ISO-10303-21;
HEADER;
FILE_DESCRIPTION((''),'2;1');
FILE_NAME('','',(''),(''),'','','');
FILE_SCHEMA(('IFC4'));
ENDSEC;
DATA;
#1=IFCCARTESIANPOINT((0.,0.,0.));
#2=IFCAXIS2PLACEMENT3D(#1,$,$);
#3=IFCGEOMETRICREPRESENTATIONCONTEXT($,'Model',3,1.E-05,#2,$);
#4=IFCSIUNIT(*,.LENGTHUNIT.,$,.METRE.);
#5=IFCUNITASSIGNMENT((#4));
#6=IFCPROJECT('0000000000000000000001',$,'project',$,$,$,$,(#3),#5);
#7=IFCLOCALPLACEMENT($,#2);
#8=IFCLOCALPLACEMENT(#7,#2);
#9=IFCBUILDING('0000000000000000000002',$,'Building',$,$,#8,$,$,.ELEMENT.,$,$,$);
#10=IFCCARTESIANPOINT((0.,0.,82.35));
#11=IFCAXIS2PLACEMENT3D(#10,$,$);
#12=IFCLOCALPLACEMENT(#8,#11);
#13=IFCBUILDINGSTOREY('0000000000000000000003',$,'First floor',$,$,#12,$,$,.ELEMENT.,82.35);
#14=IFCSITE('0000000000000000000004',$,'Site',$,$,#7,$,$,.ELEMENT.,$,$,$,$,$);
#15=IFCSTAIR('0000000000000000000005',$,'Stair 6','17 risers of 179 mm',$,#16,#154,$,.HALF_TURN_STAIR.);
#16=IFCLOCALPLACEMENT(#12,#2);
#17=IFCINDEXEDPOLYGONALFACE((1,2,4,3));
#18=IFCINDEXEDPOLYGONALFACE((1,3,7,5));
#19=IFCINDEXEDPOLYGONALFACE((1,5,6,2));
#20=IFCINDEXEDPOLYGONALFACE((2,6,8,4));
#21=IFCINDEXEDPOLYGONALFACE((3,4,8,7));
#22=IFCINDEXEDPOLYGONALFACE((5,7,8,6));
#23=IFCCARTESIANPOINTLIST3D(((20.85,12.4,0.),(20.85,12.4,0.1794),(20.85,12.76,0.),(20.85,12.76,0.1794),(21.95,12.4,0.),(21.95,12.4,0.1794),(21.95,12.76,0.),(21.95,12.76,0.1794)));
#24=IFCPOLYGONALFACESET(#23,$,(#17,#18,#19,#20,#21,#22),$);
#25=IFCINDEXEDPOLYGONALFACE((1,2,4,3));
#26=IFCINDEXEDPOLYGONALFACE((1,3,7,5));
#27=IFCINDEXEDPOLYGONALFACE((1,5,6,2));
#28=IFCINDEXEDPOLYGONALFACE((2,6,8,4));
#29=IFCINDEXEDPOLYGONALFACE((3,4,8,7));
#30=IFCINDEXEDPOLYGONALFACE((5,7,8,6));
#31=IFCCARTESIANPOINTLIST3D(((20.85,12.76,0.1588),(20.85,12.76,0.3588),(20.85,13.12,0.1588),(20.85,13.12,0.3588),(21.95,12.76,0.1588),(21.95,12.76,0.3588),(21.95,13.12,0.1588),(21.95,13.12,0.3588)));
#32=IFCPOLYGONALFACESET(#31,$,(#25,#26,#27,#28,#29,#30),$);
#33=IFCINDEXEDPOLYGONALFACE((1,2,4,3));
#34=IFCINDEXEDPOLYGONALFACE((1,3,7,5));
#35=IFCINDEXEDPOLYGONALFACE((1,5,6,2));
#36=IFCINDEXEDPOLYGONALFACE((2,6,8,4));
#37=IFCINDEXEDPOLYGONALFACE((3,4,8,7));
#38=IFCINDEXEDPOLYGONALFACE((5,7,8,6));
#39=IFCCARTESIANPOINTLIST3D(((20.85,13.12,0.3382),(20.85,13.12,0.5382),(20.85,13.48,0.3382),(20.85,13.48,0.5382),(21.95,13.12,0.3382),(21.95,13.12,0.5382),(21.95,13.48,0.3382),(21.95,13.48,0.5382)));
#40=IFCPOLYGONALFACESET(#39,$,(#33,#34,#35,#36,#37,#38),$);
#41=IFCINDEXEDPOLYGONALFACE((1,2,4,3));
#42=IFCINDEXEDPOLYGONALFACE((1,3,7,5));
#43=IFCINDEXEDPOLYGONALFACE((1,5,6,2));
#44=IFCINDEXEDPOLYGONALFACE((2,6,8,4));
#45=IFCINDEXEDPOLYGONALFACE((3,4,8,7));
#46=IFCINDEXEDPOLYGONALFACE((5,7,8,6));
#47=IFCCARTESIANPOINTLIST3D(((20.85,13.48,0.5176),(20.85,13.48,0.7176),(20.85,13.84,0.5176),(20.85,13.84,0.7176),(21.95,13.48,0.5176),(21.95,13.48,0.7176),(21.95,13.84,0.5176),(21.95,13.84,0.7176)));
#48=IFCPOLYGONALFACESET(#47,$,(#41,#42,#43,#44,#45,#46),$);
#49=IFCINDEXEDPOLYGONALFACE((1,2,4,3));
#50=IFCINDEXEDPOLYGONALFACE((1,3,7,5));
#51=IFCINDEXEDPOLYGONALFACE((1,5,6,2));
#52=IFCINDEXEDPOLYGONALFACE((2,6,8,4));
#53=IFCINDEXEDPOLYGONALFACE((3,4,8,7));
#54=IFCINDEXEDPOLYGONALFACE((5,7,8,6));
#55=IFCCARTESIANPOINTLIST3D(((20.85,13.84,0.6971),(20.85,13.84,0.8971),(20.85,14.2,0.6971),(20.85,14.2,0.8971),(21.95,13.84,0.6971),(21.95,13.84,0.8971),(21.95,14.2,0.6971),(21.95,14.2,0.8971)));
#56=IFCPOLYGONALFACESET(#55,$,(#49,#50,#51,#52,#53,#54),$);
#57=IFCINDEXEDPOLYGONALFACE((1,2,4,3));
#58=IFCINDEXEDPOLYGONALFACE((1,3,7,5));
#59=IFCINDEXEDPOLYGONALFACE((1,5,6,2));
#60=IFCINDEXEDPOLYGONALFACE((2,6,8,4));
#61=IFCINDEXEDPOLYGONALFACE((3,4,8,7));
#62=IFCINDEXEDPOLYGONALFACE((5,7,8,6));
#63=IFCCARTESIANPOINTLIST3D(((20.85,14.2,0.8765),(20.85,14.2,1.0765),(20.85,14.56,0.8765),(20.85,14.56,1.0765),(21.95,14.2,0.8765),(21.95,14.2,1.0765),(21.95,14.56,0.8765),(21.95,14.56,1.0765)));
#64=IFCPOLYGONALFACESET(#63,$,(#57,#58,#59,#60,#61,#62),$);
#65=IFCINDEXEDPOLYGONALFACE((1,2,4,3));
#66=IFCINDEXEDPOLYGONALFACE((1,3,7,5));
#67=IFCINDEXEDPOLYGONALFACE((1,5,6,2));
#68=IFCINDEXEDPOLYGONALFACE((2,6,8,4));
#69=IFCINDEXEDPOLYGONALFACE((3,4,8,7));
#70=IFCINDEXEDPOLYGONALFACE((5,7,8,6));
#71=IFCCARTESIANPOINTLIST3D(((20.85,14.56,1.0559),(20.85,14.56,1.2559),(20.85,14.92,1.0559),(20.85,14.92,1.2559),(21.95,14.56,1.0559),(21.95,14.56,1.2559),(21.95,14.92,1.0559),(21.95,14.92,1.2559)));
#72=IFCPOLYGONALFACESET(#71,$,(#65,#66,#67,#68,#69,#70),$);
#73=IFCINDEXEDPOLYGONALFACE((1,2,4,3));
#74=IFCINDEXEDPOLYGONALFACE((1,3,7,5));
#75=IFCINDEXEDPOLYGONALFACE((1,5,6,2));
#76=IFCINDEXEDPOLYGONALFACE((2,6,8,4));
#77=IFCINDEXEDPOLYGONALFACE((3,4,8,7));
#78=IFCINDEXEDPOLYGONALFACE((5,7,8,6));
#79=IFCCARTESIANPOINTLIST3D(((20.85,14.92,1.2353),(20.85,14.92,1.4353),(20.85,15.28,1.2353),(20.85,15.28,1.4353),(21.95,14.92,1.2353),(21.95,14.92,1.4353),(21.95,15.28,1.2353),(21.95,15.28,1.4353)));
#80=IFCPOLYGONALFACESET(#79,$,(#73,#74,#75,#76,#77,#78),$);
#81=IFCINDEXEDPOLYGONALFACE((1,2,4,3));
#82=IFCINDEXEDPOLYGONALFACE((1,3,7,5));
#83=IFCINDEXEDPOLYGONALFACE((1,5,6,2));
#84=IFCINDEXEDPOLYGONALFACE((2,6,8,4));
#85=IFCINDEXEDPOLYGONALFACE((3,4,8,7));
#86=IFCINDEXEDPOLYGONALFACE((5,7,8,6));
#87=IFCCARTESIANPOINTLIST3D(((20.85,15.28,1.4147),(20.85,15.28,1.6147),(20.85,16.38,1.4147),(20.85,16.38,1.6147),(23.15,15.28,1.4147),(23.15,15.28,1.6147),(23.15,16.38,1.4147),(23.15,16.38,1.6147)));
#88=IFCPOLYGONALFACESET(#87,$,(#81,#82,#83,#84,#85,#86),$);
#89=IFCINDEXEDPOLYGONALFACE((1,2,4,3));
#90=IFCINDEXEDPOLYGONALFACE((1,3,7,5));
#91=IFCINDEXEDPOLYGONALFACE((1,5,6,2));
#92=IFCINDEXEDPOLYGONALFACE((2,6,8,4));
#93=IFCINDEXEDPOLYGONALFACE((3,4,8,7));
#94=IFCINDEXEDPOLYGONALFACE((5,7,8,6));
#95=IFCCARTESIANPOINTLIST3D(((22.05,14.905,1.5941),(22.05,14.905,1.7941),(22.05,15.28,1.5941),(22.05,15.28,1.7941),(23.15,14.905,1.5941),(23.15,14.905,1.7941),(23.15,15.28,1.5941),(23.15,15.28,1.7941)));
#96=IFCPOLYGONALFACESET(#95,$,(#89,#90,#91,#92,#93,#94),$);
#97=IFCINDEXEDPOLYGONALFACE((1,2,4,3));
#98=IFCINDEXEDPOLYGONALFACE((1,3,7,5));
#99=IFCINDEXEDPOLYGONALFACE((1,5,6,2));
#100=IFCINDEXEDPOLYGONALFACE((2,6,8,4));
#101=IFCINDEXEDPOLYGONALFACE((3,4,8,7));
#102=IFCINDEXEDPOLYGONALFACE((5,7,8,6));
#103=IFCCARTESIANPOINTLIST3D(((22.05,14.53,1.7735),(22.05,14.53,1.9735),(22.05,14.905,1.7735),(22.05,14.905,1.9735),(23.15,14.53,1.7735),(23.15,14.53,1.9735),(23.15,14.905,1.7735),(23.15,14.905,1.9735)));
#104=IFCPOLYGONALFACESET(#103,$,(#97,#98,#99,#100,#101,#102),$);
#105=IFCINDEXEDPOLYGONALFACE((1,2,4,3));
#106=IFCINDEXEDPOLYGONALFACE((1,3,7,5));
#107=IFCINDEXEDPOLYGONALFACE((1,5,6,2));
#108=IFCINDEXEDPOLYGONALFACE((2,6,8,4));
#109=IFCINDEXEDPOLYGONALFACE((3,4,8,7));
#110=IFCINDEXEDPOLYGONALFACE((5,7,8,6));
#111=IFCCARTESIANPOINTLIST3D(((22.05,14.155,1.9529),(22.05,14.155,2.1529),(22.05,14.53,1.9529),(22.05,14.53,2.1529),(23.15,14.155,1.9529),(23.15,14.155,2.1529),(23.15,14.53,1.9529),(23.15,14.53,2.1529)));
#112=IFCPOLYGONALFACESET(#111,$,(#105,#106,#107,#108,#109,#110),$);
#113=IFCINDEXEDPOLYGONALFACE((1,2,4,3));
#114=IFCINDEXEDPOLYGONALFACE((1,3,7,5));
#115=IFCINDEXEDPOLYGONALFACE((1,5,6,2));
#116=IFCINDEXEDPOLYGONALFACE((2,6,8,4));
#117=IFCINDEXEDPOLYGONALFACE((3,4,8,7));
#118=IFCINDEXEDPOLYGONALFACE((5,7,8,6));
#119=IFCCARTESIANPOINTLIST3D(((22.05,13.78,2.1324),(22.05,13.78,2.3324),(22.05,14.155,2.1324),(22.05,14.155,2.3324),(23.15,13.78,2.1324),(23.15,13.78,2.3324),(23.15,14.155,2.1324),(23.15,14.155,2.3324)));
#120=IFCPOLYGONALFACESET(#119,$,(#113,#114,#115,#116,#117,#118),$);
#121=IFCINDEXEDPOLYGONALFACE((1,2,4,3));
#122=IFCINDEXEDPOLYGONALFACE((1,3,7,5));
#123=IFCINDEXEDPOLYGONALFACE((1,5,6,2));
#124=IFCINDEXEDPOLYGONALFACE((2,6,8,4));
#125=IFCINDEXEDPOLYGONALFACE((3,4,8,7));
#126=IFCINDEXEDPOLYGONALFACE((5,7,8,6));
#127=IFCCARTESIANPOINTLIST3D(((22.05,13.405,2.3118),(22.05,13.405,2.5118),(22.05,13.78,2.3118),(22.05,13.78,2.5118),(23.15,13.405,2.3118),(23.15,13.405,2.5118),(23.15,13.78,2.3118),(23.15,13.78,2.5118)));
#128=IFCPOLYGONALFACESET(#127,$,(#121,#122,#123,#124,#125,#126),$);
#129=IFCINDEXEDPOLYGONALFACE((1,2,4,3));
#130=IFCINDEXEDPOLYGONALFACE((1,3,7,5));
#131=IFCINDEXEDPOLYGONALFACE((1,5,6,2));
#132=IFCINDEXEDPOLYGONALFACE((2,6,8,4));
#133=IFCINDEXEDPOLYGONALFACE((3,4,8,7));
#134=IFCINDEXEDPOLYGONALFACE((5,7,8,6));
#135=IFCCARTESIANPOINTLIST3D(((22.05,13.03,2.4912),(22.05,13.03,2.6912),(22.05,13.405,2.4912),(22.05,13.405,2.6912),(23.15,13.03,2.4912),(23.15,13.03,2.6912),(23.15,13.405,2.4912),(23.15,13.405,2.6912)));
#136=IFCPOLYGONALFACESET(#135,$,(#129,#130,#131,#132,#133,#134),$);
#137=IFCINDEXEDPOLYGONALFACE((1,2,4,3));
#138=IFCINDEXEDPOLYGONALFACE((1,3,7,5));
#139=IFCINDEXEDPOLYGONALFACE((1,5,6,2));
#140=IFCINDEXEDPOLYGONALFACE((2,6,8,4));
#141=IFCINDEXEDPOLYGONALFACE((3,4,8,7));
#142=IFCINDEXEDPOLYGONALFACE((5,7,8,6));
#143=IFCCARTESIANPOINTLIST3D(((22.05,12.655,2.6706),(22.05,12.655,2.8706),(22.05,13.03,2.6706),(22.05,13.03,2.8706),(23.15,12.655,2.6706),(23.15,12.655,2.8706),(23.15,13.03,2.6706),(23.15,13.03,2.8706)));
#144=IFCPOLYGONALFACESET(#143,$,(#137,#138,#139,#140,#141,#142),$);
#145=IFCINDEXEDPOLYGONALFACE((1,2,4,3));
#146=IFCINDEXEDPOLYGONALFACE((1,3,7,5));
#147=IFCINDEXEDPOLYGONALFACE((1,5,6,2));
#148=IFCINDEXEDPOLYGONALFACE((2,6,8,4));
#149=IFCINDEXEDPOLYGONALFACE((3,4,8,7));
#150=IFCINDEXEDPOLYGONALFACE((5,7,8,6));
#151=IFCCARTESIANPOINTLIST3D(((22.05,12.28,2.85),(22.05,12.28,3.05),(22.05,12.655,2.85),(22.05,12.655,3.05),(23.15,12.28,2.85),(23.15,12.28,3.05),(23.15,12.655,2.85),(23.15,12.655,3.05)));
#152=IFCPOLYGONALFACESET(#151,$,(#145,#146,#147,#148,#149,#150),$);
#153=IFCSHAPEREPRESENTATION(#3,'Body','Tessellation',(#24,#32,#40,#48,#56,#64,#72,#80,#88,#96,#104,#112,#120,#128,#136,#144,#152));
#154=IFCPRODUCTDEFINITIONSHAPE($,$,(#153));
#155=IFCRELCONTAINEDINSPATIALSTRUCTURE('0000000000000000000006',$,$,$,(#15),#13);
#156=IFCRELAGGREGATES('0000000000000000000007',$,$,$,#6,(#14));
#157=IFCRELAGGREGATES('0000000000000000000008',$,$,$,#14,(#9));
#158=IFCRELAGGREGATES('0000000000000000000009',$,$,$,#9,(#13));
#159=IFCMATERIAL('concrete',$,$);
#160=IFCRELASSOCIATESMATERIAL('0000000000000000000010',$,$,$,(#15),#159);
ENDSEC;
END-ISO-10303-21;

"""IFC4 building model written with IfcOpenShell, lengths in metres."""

from ifc_helpers import new_model, si_unit, frame, origin, place, context, project, spatial, polyline, outline, extrude, material, element, save


model = new_model("IFC4")

# Units and contexts
model_context = context("Model", 3, precision=1e-05, world=origin())
ifc_project = project(units=[si_unit("LENGTHUNIT", "METRE")], contexts=[model_context])

# Site, building, storey
site_placement = place(None, origin())
site = spatial("IfcSite", under=ifc_project, at=site_placement, Name="Site", CompositionType="ELEMENT")
building_placement = place(site_placement, origin())
building = spatial("IfcBuilding", under=site, at=building_placement, Name="Building", CompositionType="ELEMENT")
storey_placement = place(building_placement, frame((0.0, 0.0, 82.35)))
storey = spatial("IfcBuildingStorey", under=building, at=storey_placement, Name="First floor", CompositionType="ELEMENT", Elevation=82.35)

# Shared definitions
ifc_material = material(Name="concrete")

# Stair
stair_1_placement = place(storey_placement, frame((21.4, 12.4, 0.0), z_axis=(0.0, 0.0, 1.0), x_axis=(0.0, 1.0, 0.0)))
element("IfcStair", 1, at=stair_1_placement, inside=storey, material=ifc_material, Name="Stair 6", Description="17 risers of 179 mm", PredefinedType="HALF_TURN_STAIR", context=model_context, shape_type="SweptSolid", body=[
    extrude(outline(polyline([(0.0, -0.55), (0.36, -0.55), (0.36, 0.55), (0.0, 0.55), (0.0, -0.55)])), origin(), (0.0, 0.0, 1.0), 0.1794),
    extrude(outline(polyline([(0.36, -0.55), (0.72, -0.55), (0.72, 0.55), (0.36, 0.55), (0.36, -0.55)])), frame((0.0, 0.0, 0.1588)), (0.0, 0.0, 1.0), 0.2),
    extrude(outline(polyline([(0.72, -0.55), (1.08, -0.55), (1.08, 0.55), (0.72, 0.55), (0.72, -0.55)])), frame((0.0, 0.0, 0.3382)), (0.0, 0.0, 1.0), 0.2),
    extrude(outline(polyline([(1.08, -0.55), (1.44, -0.55), (1.44, 0.55), (1.08, 0.55), (1.08, -0.55)])), frame((0.0, 0.0, 0.5176)), (0.0, 0.0, 1.0), 0.2),
    extrude(outline(polyline([(1.44, -0.55), (1.8, -0.55), (1.8, 0.55), (1.44, 0.55), (1.44, -0.55)])), frame((0.0, 0.0, 0.6971)), (0.0, 0.0, 1.0), 0.2),
    extrude(outline(polyline([(1.8, -0.55), (2.16, -0.55), (2.16, 0.55), (1.8, 0.55), (1.8, -0.55)])), frame((0.0, 0.0, 0.8765)), (0.0, 0.0, 1.0), 0.2),
    extrude(outline(polyline([(2.16, -0.55), (2.52, -0.55), (2.52, 0.55), (2.16, 0.55), (2.16, -0.55)])), frame((0.0, 0.0, 1.0559)), (0.0, 0.0, 1.0), 0.2),
    extrude(outline(polyline([(2.52, -0.55), (2.88, -0.55), (2.88, 0.55), (2.52, 0.55), (2.52, -0.55)])), frame((0.0, 0.0, 1.2353)), (0.0, 0.0, 1.0), 0.2),
    extrude(outline(polyline([(2.88, -1.75), (3.98, -1.75), (3.98, 0.55), (2.88, 0.55), (2.88, -1.75)])), frame((0.0, 0.0, 1.4147)), (0.0, 0.0, 1.0), 0.2),
    extrude(outline(polyline([(2.505, -1.75), (2.88, -1.75), (2.88, -0.65), (2.505, -0.65), (2.505, -1.75)])), frame((0.0, 0.0, 1.5941)), (0.0, 0.0, 1.0), 0.2),
    extrude(outline(polyline([(2.13, -1.75), (2.505, -1.75), (2.505, -0.65), (2.13, -0.65), (2.13, -1.75)])), frame((0.0, 0.0, 1.7735)), (0.0, 0.0, 1.0), 0.2),
    extrude(outline(polyline([(1.755, -1.75), (2.13, -1.75), (2.13, -0.65), (1.755, -0.65), (1.755, -1.75)])), frame((0.0, 0.0, 1.9529)), (0.0, 0.0, 1.0), 0.2),
    extrude(outline(polyline([(1.38, -1.75), (1.755, -1.75), (1.755, -0.65), (1.38, -0.65), (1.38, -1.75)])), frame((0.0, 0.0, 2.1324)), (0.0, 0.0, 1.0), 0.2),
    extrude(outline(polyline([(1.005, -1.75), (1.38, -1.75), (1.38, -0.65), (1.005, -0.65), (1.005, -1.75)])), frame((0.0, 0.0, 2.3118)), (0.0, 0.0, 1.0), 0.2),
    extrude(outline(polyline([(0.63, -1.75), (1.005, -1.75), (1.005, -0.65), (0.63, -0.65), (0.63, -1.75)])), frame((0.0, 0.0, 2.4912)), (0.0, 0.0, 1.0), 0.2),
    extrude(outline(polyline([(0.255, -1.75), (0.63, -1.75), (0.63, -0.65), (0.255, -0.65), (0.255, -1.75)])), frame((0.0, 0.0, 2.6706)), (0.0, 0.0, 1.0), 0.2),
    extrude(outline(polyline([(-0.12, -1.75), (0.255, -1.75), (0.255, -0.65), (-0.12, -0.65), (-0.12, -1.75)])), frame((0.0, 0.0, 2.85)), (0.0, 0.0, 1.0), 0.2),
])

save(model, "model.ifc")
